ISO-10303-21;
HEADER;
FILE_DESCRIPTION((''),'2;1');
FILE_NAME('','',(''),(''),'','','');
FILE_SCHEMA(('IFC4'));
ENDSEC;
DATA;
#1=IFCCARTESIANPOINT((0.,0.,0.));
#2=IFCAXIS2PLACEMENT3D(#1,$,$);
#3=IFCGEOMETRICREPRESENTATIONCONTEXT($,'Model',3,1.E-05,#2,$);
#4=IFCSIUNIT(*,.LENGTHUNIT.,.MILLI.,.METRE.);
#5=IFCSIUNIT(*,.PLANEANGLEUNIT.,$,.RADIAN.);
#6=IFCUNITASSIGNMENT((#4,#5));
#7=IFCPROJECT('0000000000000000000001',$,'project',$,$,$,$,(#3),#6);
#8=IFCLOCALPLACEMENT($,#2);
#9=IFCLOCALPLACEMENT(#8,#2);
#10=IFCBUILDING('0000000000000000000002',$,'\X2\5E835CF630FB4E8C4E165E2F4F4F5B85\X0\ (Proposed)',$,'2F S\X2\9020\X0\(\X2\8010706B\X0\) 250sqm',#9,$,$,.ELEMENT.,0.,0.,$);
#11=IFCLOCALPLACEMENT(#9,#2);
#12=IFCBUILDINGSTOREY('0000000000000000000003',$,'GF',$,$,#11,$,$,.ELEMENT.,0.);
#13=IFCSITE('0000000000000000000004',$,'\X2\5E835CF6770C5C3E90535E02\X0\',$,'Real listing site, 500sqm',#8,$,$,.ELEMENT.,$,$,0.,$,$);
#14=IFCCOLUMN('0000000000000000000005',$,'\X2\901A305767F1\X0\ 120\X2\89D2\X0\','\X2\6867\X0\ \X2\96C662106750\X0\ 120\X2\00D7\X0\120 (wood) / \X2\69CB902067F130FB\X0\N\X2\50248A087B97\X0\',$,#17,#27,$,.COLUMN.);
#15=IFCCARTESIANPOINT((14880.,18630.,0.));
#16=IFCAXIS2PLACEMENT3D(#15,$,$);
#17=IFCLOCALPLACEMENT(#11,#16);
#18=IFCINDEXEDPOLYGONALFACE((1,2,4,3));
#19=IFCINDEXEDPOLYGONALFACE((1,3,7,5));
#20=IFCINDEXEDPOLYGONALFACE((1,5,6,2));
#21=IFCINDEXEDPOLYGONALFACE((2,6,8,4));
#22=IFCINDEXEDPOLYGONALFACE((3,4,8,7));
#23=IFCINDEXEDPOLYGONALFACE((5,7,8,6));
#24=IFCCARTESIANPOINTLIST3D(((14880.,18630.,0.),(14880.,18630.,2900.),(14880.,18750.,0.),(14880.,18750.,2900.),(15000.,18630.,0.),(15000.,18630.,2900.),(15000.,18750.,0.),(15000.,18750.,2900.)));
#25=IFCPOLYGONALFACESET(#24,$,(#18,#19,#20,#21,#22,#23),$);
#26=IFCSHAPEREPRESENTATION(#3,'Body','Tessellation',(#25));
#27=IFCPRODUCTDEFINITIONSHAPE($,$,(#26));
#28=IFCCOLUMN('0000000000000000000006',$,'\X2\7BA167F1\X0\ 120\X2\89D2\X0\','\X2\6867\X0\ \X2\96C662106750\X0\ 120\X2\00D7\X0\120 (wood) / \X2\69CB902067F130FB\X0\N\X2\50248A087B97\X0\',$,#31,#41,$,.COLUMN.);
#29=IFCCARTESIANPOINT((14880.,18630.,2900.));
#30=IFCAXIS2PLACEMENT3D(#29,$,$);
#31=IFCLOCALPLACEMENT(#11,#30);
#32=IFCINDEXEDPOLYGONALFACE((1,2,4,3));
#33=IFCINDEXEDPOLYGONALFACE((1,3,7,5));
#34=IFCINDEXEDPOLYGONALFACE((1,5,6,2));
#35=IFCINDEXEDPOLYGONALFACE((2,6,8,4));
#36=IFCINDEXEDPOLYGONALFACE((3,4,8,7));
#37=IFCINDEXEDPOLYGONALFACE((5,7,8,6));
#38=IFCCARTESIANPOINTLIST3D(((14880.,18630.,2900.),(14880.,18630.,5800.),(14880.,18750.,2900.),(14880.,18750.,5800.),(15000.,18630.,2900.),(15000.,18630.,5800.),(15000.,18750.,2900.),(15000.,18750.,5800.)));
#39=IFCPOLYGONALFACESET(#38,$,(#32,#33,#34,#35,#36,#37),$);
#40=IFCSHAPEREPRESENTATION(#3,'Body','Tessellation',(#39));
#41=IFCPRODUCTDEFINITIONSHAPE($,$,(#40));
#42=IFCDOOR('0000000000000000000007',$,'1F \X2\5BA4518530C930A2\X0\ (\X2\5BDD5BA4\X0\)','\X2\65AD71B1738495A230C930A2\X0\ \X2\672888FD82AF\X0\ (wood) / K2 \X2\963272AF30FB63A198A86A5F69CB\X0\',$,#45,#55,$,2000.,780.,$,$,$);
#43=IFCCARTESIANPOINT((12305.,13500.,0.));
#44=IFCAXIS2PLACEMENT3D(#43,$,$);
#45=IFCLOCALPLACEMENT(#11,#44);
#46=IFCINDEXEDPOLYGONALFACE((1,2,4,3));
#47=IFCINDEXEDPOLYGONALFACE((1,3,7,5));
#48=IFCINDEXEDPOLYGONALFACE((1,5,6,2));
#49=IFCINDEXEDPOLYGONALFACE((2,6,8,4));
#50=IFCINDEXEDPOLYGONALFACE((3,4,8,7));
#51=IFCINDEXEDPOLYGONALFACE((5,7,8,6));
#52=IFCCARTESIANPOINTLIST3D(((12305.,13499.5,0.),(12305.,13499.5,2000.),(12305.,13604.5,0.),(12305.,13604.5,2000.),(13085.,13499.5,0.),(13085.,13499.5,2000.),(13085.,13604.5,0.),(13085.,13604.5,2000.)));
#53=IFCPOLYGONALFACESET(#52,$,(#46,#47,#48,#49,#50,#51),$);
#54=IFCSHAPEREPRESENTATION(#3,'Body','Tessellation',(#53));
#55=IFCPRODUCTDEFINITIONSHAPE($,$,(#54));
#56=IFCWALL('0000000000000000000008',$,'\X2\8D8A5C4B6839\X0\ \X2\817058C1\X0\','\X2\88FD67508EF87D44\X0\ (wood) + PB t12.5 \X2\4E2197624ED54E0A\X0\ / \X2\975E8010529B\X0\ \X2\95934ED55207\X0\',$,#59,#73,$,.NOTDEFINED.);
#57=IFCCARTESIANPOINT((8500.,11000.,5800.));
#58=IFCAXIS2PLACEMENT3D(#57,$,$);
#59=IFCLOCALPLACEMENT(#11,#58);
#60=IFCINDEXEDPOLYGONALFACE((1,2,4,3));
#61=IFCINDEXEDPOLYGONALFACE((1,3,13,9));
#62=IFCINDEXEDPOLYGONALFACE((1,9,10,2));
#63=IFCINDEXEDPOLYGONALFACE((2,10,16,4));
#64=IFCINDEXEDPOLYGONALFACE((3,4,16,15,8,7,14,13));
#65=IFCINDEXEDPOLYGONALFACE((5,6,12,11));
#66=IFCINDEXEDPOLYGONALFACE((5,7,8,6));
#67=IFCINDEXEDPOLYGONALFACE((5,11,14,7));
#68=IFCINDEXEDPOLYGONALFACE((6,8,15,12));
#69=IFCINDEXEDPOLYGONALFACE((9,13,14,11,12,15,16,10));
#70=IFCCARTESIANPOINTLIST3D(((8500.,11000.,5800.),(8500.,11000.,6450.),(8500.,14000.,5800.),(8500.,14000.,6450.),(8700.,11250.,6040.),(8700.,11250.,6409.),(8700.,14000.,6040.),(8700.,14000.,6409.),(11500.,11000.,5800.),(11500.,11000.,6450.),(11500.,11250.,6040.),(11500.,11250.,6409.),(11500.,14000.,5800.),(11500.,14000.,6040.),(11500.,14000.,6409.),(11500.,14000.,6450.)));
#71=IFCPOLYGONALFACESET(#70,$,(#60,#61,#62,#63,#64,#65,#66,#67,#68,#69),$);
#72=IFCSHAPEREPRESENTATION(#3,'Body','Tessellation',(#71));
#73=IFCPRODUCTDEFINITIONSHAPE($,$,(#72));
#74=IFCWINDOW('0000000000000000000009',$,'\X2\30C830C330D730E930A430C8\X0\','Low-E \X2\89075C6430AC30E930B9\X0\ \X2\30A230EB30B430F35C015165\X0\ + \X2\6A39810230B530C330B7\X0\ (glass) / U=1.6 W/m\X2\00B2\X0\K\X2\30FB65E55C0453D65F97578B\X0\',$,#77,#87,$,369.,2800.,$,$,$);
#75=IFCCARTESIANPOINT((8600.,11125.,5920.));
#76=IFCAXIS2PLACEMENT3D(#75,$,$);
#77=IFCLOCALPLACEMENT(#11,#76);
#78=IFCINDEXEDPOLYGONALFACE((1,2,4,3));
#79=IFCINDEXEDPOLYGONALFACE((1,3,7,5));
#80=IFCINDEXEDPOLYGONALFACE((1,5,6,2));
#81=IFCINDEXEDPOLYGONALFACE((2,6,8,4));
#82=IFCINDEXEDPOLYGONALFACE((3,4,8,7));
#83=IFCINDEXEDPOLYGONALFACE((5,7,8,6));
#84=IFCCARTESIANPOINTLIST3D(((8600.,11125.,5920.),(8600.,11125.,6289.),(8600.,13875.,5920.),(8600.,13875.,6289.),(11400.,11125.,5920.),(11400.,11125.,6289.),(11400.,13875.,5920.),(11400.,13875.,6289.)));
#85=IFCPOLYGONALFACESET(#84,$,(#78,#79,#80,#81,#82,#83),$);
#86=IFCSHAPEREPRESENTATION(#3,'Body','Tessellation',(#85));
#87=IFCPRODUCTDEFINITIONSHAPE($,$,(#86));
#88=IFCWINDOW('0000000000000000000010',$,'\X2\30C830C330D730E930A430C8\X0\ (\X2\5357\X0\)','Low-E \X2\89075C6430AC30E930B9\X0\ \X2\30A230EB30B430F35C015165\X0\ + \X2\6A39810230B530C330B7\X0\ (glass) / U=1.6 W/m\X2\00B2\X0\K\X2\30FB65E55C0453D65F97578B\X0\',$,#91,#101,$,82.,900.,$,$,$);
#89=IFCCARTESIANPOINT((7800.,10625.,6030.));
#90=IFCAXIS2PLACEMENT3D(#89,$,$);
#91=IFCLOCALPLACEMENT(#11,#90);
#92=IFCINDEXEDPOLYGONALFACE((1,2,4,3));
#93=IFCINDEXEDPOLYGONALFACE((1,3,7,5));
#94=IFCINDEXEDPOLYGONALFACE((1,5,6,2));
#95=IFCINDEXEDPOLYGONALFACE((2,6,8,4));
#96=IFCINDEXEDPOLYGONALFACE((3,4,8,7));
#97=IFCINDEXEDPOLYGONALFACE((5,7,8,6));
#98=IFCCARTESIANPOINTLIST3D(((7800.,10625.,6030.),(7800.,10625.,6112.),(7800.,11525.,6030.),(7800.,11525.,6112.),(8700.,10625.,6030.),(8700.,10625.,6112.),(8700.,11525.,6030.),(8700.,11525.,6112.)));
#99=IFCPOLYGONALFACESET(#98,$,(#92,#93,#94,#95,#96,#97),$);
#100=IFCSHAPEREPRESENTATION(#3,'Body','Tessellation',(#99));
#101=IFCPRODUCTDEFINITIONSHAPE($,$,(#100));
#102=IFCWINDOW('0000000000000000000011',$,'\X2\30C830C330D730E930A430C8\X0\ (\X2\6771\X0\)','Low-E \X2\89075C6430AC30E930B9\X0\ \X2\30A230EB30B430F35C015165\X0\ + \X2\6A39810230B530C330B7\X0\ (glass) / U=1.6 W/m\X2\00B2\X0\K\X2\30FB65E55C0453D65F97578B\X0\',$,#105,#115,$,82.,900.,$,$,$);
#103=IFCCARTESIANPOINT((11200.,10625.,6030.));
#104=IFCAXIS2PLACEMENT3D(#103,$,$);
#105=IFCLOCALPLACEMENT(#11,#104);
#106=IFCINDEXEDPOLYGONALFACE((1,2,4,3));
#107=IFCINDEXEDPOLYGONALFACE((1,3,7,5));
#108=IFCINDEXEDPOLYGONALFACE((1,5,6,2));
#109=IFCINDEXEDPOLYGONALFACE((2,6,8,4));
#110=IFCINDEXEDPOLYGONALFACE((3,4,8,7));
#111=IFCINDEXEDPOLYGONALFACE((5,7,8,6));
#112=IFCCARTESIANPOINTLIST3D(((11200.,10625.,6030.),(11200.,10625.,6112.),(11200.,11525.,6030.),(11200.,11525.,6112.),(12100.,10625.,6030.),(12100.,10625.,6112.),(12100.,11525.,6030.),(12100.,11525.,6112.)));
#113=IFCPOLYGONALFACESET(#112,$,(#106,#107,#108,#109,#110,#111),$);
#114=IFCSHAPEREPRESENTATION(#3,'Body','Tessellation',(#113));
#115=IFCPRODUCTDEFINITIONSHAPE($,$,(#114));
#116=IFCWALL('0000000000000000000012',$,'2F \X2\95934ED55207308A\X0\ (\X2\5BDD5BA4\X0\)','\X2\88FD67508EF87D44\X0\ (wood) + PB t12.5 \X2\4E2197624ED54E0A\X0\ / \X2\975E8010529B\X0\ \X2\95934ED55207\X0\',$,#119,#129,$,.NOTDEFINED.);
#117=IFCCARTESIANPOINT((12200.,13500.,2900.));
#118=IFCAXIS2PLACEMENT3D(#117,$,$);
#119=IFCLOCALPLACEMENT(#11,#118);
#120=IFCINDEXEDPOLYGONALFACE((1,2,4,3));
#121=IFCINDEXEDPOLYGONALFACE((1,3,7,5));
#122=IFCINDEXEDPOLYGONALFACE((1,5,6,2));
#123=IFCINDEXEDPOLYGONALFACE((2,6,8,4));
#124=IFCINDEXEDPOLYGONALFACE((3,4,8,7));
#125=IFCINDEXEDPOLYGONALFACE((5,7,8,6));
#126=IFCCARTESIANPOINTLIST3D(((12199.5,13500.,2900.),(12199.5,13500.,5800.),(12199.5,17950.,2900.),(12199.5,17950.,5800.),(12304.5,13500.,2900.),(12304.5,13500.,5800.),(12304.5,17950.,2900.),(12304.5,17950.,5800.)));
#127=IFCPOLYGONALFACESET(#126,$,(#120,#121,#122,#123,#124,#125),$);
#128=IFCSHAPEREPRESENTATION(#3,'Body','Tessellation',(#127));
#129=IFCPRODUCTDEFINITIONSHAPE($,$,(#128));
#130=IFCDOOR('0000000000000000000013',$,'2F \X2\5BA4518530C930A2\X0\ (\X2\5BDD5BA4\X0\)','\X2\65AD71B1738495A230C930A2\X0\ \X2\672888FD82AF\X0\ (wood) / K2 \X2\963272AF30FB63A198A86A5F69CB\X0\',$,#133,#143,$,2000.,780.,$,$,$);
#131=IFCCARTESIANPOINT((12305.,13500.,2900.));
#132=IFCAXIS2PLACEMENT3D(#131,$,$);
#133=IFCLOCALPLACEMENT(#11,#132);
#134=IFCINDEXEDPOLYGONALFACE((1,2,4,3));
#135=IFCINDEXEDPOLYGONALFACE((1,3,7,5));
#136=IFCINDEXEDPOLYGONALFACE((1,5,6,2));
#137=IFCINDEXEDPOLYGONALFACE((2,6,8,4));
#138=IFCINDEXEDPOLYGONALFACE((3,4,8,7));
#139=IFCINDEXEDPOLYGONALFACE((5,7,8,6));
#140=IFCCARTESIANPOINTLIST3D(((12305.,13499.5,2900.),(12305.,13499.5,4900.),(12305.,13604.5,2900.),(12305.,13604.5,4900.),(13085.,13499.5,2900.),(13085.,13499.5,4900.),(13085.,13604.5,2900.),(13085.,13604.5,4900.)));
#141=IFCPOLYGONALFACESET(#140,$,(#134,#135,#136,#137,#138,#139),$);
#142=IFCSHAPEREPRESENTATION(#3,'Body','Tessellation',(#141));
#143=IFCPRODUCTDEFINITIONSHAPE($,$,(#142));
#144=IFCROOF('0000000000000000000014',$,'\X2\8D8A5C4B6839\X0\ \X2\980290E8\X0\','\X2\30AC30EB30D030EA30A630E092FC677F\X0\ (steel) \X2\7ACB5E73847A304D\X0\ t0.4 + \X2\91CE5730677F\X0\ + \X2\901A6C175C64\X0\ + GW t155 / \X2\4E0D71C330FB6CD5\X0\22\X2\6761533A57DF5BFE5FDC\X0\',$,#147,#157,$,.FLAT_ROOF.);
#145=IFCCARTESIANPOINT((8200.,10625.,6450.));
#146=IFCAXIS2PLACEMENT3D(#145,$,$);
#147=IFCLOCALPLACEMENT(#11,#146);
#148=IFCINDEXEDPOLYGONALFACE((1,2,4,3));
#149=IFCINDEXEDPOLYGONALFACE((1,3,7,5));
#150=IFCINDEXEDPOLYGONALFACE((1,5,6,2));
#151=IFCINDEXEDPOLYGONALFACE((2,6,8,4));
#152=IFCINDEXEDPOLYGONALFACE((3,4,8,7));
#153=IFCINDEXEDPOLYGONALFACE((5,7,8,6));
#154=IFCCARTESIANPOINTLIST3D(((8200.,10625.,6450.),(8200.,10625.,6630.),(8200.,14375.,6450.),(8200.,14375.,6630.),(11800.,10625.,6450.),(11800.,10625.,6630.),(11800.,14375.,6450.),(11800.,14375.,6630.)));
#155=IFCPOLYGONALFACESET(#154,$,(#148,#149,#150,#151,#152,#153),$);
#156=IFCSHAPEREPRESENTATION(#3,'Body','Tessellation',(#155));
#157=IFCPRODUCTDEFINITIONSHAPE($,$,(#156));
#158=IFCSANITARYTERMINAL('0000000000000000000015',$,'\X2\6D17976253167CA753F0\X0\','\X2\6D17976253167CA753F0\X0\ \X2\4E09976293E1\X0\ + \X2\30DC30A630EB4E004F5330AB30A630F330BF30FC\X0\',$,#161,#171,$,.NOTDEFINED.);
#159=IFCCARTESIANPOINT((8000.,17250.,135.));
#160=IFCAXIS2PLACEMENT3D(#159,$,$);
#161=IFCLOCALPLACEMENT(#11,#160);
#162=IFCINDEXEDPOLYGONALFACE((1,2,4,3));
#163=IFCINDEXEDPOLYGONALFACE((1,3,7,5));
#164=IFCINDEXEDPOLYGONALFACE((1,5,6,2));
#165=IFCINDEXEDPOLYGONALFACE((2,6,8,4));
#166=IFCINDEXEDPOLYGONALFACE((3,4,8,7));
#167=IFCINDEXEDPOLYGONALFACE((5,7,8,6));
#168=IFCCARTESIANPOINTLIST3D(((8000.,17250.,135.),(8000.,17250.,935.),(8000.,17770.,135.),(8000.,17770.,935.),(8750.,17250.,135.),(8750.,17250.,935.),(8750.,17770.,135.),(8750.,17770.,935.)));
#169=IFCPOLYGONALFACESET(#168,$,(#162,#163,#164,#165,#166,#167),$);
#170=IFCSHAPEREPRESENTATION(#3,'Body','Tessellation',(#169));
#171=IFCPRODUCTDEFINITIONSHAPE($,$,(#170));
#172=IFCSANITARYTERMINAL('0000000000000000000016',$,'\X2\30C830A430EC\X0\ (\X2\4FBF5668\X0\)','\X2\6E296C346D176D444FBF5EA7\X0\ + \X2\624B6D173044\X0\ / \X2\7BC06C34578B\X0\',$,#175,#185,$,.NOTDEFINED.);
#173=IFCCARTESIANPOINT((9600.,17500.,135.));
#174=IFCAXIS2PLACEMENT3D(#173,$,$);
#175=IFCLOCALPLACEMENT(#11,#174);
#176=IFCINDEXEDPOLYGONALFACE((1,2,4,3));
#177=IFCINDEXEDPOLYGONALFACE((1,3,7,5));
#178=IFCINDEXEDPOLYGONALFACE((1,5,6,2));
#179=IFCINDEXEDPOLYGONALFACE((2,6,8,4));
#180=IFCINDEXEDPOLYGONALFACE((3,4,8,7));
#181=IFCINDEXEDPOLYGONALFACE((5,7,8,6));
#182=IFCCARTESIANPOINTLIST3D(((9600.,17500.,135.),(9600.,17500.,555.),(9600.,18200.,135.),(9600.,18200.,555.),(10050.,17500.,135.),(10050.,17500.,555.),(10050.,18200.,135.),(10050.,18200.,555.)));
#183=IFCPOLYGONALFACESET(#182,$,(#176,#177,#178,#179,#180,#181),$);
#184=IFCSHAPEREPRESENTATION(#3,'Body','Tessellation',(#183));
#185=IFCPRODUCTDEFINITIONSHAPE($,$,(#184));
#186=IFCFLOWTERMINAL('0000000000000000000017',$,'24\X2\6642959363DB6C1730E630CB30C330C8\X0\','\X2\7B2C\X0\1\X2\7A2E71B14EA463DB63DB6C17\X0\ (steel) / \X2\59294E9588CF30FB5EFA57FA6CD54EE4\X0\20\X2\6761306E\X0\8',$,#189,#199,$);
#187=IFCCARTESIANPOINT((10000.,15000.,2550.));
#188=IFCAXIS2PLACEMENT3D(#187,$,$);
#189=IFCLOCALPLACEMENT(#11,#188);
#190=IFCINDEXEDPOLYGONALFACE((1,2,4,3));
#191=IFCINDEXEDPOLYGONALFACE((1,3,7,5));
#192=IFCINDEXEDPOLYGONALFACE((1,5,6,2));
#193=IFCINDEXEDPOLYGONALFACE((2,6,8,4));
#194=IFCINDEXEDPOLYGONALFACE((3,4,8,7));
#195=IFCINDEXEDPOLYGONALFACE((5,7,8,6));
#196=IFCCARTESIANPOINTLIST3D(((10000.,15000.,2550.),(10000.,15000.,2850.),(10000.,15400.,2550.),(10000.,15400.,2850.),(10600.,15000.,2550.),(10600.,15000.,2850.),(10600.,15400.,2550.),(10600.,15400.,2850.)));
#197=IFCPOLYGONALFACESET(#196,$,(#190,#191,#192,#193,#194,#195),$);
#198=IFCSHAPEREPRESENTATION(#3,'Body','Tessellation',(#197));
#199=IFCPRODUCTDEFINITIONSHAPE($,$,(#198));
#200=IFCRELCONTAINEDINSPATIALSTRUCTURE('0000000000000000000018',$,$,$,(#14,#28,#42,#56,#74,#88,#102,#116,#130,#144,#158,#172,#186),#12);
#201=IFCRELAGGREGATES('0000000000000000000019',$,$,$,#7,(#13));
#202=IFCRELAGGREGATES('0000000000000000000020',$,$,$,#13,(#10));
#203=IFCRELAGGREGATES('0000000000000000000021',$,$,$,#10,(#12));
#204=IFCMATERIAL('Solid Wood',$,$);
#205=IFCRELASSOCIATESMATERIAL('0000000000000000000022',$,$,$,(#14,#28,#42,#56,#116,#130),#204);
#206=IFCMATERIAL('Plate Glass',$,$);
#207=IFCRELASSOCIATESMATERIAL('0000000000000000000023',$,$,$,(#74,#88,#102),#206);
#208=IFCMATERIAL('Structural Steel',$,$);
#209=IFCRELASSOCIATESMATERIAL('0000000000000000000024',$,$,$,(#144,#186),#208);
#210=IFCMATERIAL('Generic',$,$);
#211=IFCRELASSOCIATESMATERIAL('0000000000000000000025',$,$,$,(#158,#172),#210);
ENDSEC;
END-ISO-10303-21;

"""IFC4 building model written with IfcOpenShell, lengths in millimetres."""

from ifc_helpers import new_model, si_unit, frame, frame_2d, origin, place, context, project, spatial, rectangle, extrude, material, element, fill, save


model = new_model("IFC4")

# Units and contexts
model_context = context("Model", 3, precision=1e-05, world=origin())
ifc_project = project(units=[si_unit("LENGTHUNIT", "METRE", prefix="MILLI"), si_unit("PLANEANGLEUNIT", "RADIAN")], contexts=[model_context])

# Site, building, storey
site_placement = place(None, origin())
site = spatial("IfcSite", under=ifc_project, at=site_placement, Name="広島県尾道市", ObjectType="Real listing site, 500sqm", CompositionType="ELEMENT", RefElevation=0.0)
building_placement = place(site_placement, origin())
building = spatial("IfcBuilding", under=site, at=building_placement, Name="広島・二世帯住宅 (Proposed)", ObjectType="2F S造(耐火) 250sqm", CompositionType="ELEMENT", ElevationOfRefHeight=0.0, ElevationOfTerrain=0.0)
storey_placement = place(building_placement, origin())
storey = spatial("IfcBuildingStorey", under=building, at=storey_placement, Name="GF", CompositionType="ELEMENT", Elevation=0.0)

# Columns
ifc_material_1 = material(Name="Solid Wood")
column_1_placement = place(storey_placement, frame((14880.0, 18630.0, 0.0)))
element("IfcColumn", 1, at=column_1_placement, inside=storey, material=ifc_material_1, Name="通し柱 120角", Description="桧 集成材 120×120 (wood) / 構造柱・N値計算", PredefinedType="COLUMN", context=model_context, shape_type="SweptSolid", body=[
    extrude(rectangle(XDim=120.0, YDim=120.0, at=frame_2d((60.0, 60.0))), frame((14880.0, 18630.0, 0.0)), (0.0, 0.0, 1.0), 2900.0),
])
column_2_placement = place(storey_placement, frame((14880.0, 18630.0, 2900.0)))
element("IfcColumn", 2, at=column_2_placement, inside=storey, material=ifc_material_1, Name="管柱 120角", Description="桧 集成材 120×120 (wood) / 構造柱・N値計算", PredefinedType="COLUMN", context=model_context, shape_type="SweptSolid", body=[
    extrude(rectangle(XDim=120.0, YDim=120.0, at=frame_2d((60.0, 60.0))), frame((14880.0, 18630.0, 2900.0)), (0.0, 0.0, 1.0), 2900.0),
])

# Door
door_1_placement = place(storey_placement, frame((12305.0, 13500.0, 0.0)))
element("IfcDoor", 3, at=door_1_placement, inside=storey, material=ifc_material_1, Name="1F 室内ドア (寝室)", Description="断熱玄関ドア 木製芯 (wood) / K2 防犯・採風機構", OverallHeight=2000.0, OverallWidth=780.0, context=model_context, shape_type="SweptSolid", body=[
    extrude(rectangle(XDim=780.0, YDim=105.0, at=frame_2d((390.0, 52.0))), frame((12305.0, 13500.0, 0.0)), (0.0, 0.0, 1.0), 2000.0),
])

# Wall, openings, windows
wall_1_placement = place(storey_placement, frame((8500.0, 11000.0, 5800.0)))
wall_1 = element("IfcWall", 4, at=wall_1_placement, inside=storey, material=ifc_material_1, Name="越屋根 腰壁", Description="製材軸組 (wood) + PB t12.5 両面仕上 / 非耐力 間仕切", PredefinedType="NOTDEFINED", context=model_context, shape_type="SweptSolid", body=[
    extrude(rectangle(XDim=3000.0, YDim=3000.0, at=frame_2d((1500.0, 1500.0))), frame((8500.0, 11000.0, 5800.0)), (0.0, 0.0, 1.0), 650.0),
])
opening_1_placement = place(storey_placement, frame((8600.0, 11125.0, 5920.0)))
opening_1 = element("IfcOpeningElement", 5, at=opening_1_placement, cuts=wall_1, PredefinedType="NOTDEFINED", context=model_context, shape_type="SweptSolid", body=[
    extrude(rectangle(XDim=2800.0, YDim=2750.0, at=frame_2d((1400.0, 1375.0))), frame((8600.0, 11125.0, 5920.0)), (0.0, 0.0, 1.0), 369.0),
])
opening_2_placement = place(storey_placement, frame((7800.0, 10625.0, 6030.0)))
opening_2 = element("IfcOpeningElement", 6, at=opening_2_placement, cuts=wall_1, PredefinedType="NOTDEFINED", context=model_context, shape_type="SweptSolid", body=[
    extrude(rectangle(XDim=900.0, YDim=900.0, at=frame_2d((450.0, 450.0))), frame((7800.0, 10625.0, 6030.0)), (0.0, 0.0, 1.0), 82.0),
])
opening_3_placement = place(storey_placement, frame((11200.0, 10625.0, 6030.0)))
opening_3 = element("IfcOpeningElement", 7, at=opening_3_placement, cuts=wall_1, PredefinedType="NOTDEFINED", context=model_context, shape_type="SweptSolid", body=[
    extrude(rectangle(XDim=900.0, YDim=900.0, at=frame_2d((450.0, 450.0))), frame((11200.0, 10625.0, 6030.0)), (0.0, 0.0, 1.0), 82.0),
])
ifc_material_2 = material(Name="Plate Glass")
window_1_placement = place(storey_placement, frame((8600.0, 11125.0, 5920.0)))
window_1 = element("IfcWindow", 8, at=window_1_placement, inside=storey, material=ifc_material_2, Name="トップライト", Description="Low-E 複層ガラス アルゴン封入 + 樹脂サッシ (glass) / U=1.6 W/m²K・日射取得型", OverallHeight=369.0, OverallWidth=2800.0, context=model_context, shape_type="SweptSolid", body=[
    extrude(rectangle(XDim=2800.0, YDim=2750.0, at=frame_2d((1400.0, 1375.0))), frame((8600.0, 11125.0, 5920.0)), (0.0, 0.0, 1.0), 369.0),
])
fill(opening_1, window_1)
window_2_placement = place(storey_placement, frame((7800.0, 10625.0, 6030.0)))
window_2 = element("IfcWindow", 9, at=window_2_placement, inside=storey, material=ifc_material_2, Name="トップライト (南)", Description="Low-E 複層ガラス アルゴン封入 + 樹脂サッシ (glass) / U=1.6 W/m²K・日射取得型", OverallHeight=82.0, OverallWidth=900.0, context=model_context, shape_type="SweptSolid", body=[
    extrude(rectangle(XDim=900.0, YDim=900.0, at=frame_2d((450.0, 450.0))), frame((7800.0, 10625.0, 6030.0)), (0.0, 0.0, 1.0), 82.0),
])
fill(opening_2, window_2)
window_3_placement = place(storey_placement, frame((11200.0, 10625.0, 6030.0)))
window_3 = element("IfcWindow", 10, at=window_3_placement, inside=storey, material=ifc_material_2, Name="トップライト (東)", Description="Low-E 複層ガラス アルゴン封入 + 樹脂サッシ (glass) / U=1.6 W/m²K・日射取得型", OverallHeight=82.0, OverallWidth=900.0, context=model_context, shape_type="SweptSolid", body=[
    extrude(rectangle(XDim=900.0, YDim=900.0, at=frame_2d((450.0, 450.0))), frame((11200.0, 10625.0, 6030.0)), (0.0, 0.0, 1.0), 82.0),
])
fill(opening_3, window_3)

# Wall
wall_2_placement = place(storey_placement, frame((12200.0, 13500.0, 2900.0)))
element("IfcWall", 11, at=wall_2_placement, inside=storey, material=ifc_material_1, Name="2F 間仕切り (寝室)", Description="製材軸組 (wood) + PB t12.5 両面仕上 / 非耐力 間仕切", PredefinedType="NOTDEFINED", context=model_context, shape_type="SweptSolid", body=[
    extrude(rectangle(XDim=105.0, YDim=4450.0, at=frame_2d((52.0, 2225.0))), frame((12200.0, 13500.0, 2900.0)), (0.0, 0.0, 1.0), 2900.0),
])

# Door
door_2_placement = place(storey_placement, frame((12305.0, 13500.0, 2900.0)))
element("IfcDoor", 12, at=door_2_placement, inside=storey, material=ifc_material_1, Name="2F 室内ドア (寝室)", Description="断熱玄関ドア 木製芯 (wood) / K2 防犯・採風機構", OverallHeight=2000.0, OverallWidth=780.0, context=model_context, shape_type="SweptSolid", body=[
    extrude(rectangle(XDim=780.0, YDim=105.0, at=frame_2d((390.0, 52.0))), frame((12305.0, 13500.0, 2900.0)), (0.0, 0.0, 1.0), 2000.0),
])

# Roof
ifc_material_3 = material(Name="Structural Steel")
roof_placement = place(storey_placement, frame((8200.0, 10625.0, 6450.0)))
element("IfcRoof", 13, at=roof_placement, inside=storey, material=ifc_material_3, Name="越屋根 頂部", Description="ガルバリウム鋼板 (steel) 立平葺き t0.4 + 野地板 + 通気層 + GW t155 / 不燃・法22条区域対応", PredefinedType="FLAT_ROOF", context=model_context, shape_type="SweptSolid", body=[
    extrude(rectangle(XDim=3600.0, YDim=3750.0, at=frame_2d((1800.0, 1875.0))), frame((8200.0, 10625.0, 6450.0)), (0.0, 0.0, 1.0), 180.0),
])

# Sanitary terminals
ifc_material_4 = material(Name="Generic")
sanitary_terminal_1_placement = place(storey_placement, frame((8000.0, 17250.0, 135.0)))
element("IfcSanitaryTerminal", 14, at=sanitary_terminal_1_placement, inside=storey, material=ifc_material_4, Name="洗面化粧台", Description="洗面化粧台 三面鏡 + ボウル一体カウンター", PredefinedType="NOTDEFINED", context=model_context, shape_type="SweptSolid", body=[
    extrude(rectangle(XDim=750.0, YDim=520.0, at=frame_2d((375.0, 260.0))), frame((8000.0, 17250.0, 135.0)), (0.0, 0.0, 1.0), 800.0),
])
sanitary_terminal_2_placement = place(storey_placement, frame((9600.0, 17500.0, 135.0)))
element("IfcSanitaryTerminal", 15, at=sanitary_terminal_2_placement, inside=storey, material=ifc_material_4, Name="トイレ (便器)", Description="温水洗浄便座 + 手洗い / 節水型", PredefinedType="NOTDEFINED", context=model_context, shape_type="SweptSolid", body=[
    extrude(rectangle(XDim=450.0, YDim=700.0, at=frame_2d((225.0, 350.0))), frame((9600.0, 17500.0, 135.0)), (0.0, 0.0, 1.0), 420.0),
])

# Flow terminal
flow_terminal_placement = place(storey_placement, frame((10000.0, 15000.0, 2550.0)))
element("IfcFlowTerminal", 16, at=flow_terminal_placement, inside=storey, material=ifc_material_3, Name="24時間換気ユニット", Description="第1種熱交換換気 (steel) / 天井裏・建基法令20条の8", context=model_context, shape_type="SweptSolid", body=[
    extrude(rectangle(XDim=600.0, YDim=400.0, at=frame_2d((300.0, 200.0))), frame((10000.0, 15000.0, 2550.0)), (0.0, 0.0, 1.0), 300.0),
])

save(model, "model.ifc")
